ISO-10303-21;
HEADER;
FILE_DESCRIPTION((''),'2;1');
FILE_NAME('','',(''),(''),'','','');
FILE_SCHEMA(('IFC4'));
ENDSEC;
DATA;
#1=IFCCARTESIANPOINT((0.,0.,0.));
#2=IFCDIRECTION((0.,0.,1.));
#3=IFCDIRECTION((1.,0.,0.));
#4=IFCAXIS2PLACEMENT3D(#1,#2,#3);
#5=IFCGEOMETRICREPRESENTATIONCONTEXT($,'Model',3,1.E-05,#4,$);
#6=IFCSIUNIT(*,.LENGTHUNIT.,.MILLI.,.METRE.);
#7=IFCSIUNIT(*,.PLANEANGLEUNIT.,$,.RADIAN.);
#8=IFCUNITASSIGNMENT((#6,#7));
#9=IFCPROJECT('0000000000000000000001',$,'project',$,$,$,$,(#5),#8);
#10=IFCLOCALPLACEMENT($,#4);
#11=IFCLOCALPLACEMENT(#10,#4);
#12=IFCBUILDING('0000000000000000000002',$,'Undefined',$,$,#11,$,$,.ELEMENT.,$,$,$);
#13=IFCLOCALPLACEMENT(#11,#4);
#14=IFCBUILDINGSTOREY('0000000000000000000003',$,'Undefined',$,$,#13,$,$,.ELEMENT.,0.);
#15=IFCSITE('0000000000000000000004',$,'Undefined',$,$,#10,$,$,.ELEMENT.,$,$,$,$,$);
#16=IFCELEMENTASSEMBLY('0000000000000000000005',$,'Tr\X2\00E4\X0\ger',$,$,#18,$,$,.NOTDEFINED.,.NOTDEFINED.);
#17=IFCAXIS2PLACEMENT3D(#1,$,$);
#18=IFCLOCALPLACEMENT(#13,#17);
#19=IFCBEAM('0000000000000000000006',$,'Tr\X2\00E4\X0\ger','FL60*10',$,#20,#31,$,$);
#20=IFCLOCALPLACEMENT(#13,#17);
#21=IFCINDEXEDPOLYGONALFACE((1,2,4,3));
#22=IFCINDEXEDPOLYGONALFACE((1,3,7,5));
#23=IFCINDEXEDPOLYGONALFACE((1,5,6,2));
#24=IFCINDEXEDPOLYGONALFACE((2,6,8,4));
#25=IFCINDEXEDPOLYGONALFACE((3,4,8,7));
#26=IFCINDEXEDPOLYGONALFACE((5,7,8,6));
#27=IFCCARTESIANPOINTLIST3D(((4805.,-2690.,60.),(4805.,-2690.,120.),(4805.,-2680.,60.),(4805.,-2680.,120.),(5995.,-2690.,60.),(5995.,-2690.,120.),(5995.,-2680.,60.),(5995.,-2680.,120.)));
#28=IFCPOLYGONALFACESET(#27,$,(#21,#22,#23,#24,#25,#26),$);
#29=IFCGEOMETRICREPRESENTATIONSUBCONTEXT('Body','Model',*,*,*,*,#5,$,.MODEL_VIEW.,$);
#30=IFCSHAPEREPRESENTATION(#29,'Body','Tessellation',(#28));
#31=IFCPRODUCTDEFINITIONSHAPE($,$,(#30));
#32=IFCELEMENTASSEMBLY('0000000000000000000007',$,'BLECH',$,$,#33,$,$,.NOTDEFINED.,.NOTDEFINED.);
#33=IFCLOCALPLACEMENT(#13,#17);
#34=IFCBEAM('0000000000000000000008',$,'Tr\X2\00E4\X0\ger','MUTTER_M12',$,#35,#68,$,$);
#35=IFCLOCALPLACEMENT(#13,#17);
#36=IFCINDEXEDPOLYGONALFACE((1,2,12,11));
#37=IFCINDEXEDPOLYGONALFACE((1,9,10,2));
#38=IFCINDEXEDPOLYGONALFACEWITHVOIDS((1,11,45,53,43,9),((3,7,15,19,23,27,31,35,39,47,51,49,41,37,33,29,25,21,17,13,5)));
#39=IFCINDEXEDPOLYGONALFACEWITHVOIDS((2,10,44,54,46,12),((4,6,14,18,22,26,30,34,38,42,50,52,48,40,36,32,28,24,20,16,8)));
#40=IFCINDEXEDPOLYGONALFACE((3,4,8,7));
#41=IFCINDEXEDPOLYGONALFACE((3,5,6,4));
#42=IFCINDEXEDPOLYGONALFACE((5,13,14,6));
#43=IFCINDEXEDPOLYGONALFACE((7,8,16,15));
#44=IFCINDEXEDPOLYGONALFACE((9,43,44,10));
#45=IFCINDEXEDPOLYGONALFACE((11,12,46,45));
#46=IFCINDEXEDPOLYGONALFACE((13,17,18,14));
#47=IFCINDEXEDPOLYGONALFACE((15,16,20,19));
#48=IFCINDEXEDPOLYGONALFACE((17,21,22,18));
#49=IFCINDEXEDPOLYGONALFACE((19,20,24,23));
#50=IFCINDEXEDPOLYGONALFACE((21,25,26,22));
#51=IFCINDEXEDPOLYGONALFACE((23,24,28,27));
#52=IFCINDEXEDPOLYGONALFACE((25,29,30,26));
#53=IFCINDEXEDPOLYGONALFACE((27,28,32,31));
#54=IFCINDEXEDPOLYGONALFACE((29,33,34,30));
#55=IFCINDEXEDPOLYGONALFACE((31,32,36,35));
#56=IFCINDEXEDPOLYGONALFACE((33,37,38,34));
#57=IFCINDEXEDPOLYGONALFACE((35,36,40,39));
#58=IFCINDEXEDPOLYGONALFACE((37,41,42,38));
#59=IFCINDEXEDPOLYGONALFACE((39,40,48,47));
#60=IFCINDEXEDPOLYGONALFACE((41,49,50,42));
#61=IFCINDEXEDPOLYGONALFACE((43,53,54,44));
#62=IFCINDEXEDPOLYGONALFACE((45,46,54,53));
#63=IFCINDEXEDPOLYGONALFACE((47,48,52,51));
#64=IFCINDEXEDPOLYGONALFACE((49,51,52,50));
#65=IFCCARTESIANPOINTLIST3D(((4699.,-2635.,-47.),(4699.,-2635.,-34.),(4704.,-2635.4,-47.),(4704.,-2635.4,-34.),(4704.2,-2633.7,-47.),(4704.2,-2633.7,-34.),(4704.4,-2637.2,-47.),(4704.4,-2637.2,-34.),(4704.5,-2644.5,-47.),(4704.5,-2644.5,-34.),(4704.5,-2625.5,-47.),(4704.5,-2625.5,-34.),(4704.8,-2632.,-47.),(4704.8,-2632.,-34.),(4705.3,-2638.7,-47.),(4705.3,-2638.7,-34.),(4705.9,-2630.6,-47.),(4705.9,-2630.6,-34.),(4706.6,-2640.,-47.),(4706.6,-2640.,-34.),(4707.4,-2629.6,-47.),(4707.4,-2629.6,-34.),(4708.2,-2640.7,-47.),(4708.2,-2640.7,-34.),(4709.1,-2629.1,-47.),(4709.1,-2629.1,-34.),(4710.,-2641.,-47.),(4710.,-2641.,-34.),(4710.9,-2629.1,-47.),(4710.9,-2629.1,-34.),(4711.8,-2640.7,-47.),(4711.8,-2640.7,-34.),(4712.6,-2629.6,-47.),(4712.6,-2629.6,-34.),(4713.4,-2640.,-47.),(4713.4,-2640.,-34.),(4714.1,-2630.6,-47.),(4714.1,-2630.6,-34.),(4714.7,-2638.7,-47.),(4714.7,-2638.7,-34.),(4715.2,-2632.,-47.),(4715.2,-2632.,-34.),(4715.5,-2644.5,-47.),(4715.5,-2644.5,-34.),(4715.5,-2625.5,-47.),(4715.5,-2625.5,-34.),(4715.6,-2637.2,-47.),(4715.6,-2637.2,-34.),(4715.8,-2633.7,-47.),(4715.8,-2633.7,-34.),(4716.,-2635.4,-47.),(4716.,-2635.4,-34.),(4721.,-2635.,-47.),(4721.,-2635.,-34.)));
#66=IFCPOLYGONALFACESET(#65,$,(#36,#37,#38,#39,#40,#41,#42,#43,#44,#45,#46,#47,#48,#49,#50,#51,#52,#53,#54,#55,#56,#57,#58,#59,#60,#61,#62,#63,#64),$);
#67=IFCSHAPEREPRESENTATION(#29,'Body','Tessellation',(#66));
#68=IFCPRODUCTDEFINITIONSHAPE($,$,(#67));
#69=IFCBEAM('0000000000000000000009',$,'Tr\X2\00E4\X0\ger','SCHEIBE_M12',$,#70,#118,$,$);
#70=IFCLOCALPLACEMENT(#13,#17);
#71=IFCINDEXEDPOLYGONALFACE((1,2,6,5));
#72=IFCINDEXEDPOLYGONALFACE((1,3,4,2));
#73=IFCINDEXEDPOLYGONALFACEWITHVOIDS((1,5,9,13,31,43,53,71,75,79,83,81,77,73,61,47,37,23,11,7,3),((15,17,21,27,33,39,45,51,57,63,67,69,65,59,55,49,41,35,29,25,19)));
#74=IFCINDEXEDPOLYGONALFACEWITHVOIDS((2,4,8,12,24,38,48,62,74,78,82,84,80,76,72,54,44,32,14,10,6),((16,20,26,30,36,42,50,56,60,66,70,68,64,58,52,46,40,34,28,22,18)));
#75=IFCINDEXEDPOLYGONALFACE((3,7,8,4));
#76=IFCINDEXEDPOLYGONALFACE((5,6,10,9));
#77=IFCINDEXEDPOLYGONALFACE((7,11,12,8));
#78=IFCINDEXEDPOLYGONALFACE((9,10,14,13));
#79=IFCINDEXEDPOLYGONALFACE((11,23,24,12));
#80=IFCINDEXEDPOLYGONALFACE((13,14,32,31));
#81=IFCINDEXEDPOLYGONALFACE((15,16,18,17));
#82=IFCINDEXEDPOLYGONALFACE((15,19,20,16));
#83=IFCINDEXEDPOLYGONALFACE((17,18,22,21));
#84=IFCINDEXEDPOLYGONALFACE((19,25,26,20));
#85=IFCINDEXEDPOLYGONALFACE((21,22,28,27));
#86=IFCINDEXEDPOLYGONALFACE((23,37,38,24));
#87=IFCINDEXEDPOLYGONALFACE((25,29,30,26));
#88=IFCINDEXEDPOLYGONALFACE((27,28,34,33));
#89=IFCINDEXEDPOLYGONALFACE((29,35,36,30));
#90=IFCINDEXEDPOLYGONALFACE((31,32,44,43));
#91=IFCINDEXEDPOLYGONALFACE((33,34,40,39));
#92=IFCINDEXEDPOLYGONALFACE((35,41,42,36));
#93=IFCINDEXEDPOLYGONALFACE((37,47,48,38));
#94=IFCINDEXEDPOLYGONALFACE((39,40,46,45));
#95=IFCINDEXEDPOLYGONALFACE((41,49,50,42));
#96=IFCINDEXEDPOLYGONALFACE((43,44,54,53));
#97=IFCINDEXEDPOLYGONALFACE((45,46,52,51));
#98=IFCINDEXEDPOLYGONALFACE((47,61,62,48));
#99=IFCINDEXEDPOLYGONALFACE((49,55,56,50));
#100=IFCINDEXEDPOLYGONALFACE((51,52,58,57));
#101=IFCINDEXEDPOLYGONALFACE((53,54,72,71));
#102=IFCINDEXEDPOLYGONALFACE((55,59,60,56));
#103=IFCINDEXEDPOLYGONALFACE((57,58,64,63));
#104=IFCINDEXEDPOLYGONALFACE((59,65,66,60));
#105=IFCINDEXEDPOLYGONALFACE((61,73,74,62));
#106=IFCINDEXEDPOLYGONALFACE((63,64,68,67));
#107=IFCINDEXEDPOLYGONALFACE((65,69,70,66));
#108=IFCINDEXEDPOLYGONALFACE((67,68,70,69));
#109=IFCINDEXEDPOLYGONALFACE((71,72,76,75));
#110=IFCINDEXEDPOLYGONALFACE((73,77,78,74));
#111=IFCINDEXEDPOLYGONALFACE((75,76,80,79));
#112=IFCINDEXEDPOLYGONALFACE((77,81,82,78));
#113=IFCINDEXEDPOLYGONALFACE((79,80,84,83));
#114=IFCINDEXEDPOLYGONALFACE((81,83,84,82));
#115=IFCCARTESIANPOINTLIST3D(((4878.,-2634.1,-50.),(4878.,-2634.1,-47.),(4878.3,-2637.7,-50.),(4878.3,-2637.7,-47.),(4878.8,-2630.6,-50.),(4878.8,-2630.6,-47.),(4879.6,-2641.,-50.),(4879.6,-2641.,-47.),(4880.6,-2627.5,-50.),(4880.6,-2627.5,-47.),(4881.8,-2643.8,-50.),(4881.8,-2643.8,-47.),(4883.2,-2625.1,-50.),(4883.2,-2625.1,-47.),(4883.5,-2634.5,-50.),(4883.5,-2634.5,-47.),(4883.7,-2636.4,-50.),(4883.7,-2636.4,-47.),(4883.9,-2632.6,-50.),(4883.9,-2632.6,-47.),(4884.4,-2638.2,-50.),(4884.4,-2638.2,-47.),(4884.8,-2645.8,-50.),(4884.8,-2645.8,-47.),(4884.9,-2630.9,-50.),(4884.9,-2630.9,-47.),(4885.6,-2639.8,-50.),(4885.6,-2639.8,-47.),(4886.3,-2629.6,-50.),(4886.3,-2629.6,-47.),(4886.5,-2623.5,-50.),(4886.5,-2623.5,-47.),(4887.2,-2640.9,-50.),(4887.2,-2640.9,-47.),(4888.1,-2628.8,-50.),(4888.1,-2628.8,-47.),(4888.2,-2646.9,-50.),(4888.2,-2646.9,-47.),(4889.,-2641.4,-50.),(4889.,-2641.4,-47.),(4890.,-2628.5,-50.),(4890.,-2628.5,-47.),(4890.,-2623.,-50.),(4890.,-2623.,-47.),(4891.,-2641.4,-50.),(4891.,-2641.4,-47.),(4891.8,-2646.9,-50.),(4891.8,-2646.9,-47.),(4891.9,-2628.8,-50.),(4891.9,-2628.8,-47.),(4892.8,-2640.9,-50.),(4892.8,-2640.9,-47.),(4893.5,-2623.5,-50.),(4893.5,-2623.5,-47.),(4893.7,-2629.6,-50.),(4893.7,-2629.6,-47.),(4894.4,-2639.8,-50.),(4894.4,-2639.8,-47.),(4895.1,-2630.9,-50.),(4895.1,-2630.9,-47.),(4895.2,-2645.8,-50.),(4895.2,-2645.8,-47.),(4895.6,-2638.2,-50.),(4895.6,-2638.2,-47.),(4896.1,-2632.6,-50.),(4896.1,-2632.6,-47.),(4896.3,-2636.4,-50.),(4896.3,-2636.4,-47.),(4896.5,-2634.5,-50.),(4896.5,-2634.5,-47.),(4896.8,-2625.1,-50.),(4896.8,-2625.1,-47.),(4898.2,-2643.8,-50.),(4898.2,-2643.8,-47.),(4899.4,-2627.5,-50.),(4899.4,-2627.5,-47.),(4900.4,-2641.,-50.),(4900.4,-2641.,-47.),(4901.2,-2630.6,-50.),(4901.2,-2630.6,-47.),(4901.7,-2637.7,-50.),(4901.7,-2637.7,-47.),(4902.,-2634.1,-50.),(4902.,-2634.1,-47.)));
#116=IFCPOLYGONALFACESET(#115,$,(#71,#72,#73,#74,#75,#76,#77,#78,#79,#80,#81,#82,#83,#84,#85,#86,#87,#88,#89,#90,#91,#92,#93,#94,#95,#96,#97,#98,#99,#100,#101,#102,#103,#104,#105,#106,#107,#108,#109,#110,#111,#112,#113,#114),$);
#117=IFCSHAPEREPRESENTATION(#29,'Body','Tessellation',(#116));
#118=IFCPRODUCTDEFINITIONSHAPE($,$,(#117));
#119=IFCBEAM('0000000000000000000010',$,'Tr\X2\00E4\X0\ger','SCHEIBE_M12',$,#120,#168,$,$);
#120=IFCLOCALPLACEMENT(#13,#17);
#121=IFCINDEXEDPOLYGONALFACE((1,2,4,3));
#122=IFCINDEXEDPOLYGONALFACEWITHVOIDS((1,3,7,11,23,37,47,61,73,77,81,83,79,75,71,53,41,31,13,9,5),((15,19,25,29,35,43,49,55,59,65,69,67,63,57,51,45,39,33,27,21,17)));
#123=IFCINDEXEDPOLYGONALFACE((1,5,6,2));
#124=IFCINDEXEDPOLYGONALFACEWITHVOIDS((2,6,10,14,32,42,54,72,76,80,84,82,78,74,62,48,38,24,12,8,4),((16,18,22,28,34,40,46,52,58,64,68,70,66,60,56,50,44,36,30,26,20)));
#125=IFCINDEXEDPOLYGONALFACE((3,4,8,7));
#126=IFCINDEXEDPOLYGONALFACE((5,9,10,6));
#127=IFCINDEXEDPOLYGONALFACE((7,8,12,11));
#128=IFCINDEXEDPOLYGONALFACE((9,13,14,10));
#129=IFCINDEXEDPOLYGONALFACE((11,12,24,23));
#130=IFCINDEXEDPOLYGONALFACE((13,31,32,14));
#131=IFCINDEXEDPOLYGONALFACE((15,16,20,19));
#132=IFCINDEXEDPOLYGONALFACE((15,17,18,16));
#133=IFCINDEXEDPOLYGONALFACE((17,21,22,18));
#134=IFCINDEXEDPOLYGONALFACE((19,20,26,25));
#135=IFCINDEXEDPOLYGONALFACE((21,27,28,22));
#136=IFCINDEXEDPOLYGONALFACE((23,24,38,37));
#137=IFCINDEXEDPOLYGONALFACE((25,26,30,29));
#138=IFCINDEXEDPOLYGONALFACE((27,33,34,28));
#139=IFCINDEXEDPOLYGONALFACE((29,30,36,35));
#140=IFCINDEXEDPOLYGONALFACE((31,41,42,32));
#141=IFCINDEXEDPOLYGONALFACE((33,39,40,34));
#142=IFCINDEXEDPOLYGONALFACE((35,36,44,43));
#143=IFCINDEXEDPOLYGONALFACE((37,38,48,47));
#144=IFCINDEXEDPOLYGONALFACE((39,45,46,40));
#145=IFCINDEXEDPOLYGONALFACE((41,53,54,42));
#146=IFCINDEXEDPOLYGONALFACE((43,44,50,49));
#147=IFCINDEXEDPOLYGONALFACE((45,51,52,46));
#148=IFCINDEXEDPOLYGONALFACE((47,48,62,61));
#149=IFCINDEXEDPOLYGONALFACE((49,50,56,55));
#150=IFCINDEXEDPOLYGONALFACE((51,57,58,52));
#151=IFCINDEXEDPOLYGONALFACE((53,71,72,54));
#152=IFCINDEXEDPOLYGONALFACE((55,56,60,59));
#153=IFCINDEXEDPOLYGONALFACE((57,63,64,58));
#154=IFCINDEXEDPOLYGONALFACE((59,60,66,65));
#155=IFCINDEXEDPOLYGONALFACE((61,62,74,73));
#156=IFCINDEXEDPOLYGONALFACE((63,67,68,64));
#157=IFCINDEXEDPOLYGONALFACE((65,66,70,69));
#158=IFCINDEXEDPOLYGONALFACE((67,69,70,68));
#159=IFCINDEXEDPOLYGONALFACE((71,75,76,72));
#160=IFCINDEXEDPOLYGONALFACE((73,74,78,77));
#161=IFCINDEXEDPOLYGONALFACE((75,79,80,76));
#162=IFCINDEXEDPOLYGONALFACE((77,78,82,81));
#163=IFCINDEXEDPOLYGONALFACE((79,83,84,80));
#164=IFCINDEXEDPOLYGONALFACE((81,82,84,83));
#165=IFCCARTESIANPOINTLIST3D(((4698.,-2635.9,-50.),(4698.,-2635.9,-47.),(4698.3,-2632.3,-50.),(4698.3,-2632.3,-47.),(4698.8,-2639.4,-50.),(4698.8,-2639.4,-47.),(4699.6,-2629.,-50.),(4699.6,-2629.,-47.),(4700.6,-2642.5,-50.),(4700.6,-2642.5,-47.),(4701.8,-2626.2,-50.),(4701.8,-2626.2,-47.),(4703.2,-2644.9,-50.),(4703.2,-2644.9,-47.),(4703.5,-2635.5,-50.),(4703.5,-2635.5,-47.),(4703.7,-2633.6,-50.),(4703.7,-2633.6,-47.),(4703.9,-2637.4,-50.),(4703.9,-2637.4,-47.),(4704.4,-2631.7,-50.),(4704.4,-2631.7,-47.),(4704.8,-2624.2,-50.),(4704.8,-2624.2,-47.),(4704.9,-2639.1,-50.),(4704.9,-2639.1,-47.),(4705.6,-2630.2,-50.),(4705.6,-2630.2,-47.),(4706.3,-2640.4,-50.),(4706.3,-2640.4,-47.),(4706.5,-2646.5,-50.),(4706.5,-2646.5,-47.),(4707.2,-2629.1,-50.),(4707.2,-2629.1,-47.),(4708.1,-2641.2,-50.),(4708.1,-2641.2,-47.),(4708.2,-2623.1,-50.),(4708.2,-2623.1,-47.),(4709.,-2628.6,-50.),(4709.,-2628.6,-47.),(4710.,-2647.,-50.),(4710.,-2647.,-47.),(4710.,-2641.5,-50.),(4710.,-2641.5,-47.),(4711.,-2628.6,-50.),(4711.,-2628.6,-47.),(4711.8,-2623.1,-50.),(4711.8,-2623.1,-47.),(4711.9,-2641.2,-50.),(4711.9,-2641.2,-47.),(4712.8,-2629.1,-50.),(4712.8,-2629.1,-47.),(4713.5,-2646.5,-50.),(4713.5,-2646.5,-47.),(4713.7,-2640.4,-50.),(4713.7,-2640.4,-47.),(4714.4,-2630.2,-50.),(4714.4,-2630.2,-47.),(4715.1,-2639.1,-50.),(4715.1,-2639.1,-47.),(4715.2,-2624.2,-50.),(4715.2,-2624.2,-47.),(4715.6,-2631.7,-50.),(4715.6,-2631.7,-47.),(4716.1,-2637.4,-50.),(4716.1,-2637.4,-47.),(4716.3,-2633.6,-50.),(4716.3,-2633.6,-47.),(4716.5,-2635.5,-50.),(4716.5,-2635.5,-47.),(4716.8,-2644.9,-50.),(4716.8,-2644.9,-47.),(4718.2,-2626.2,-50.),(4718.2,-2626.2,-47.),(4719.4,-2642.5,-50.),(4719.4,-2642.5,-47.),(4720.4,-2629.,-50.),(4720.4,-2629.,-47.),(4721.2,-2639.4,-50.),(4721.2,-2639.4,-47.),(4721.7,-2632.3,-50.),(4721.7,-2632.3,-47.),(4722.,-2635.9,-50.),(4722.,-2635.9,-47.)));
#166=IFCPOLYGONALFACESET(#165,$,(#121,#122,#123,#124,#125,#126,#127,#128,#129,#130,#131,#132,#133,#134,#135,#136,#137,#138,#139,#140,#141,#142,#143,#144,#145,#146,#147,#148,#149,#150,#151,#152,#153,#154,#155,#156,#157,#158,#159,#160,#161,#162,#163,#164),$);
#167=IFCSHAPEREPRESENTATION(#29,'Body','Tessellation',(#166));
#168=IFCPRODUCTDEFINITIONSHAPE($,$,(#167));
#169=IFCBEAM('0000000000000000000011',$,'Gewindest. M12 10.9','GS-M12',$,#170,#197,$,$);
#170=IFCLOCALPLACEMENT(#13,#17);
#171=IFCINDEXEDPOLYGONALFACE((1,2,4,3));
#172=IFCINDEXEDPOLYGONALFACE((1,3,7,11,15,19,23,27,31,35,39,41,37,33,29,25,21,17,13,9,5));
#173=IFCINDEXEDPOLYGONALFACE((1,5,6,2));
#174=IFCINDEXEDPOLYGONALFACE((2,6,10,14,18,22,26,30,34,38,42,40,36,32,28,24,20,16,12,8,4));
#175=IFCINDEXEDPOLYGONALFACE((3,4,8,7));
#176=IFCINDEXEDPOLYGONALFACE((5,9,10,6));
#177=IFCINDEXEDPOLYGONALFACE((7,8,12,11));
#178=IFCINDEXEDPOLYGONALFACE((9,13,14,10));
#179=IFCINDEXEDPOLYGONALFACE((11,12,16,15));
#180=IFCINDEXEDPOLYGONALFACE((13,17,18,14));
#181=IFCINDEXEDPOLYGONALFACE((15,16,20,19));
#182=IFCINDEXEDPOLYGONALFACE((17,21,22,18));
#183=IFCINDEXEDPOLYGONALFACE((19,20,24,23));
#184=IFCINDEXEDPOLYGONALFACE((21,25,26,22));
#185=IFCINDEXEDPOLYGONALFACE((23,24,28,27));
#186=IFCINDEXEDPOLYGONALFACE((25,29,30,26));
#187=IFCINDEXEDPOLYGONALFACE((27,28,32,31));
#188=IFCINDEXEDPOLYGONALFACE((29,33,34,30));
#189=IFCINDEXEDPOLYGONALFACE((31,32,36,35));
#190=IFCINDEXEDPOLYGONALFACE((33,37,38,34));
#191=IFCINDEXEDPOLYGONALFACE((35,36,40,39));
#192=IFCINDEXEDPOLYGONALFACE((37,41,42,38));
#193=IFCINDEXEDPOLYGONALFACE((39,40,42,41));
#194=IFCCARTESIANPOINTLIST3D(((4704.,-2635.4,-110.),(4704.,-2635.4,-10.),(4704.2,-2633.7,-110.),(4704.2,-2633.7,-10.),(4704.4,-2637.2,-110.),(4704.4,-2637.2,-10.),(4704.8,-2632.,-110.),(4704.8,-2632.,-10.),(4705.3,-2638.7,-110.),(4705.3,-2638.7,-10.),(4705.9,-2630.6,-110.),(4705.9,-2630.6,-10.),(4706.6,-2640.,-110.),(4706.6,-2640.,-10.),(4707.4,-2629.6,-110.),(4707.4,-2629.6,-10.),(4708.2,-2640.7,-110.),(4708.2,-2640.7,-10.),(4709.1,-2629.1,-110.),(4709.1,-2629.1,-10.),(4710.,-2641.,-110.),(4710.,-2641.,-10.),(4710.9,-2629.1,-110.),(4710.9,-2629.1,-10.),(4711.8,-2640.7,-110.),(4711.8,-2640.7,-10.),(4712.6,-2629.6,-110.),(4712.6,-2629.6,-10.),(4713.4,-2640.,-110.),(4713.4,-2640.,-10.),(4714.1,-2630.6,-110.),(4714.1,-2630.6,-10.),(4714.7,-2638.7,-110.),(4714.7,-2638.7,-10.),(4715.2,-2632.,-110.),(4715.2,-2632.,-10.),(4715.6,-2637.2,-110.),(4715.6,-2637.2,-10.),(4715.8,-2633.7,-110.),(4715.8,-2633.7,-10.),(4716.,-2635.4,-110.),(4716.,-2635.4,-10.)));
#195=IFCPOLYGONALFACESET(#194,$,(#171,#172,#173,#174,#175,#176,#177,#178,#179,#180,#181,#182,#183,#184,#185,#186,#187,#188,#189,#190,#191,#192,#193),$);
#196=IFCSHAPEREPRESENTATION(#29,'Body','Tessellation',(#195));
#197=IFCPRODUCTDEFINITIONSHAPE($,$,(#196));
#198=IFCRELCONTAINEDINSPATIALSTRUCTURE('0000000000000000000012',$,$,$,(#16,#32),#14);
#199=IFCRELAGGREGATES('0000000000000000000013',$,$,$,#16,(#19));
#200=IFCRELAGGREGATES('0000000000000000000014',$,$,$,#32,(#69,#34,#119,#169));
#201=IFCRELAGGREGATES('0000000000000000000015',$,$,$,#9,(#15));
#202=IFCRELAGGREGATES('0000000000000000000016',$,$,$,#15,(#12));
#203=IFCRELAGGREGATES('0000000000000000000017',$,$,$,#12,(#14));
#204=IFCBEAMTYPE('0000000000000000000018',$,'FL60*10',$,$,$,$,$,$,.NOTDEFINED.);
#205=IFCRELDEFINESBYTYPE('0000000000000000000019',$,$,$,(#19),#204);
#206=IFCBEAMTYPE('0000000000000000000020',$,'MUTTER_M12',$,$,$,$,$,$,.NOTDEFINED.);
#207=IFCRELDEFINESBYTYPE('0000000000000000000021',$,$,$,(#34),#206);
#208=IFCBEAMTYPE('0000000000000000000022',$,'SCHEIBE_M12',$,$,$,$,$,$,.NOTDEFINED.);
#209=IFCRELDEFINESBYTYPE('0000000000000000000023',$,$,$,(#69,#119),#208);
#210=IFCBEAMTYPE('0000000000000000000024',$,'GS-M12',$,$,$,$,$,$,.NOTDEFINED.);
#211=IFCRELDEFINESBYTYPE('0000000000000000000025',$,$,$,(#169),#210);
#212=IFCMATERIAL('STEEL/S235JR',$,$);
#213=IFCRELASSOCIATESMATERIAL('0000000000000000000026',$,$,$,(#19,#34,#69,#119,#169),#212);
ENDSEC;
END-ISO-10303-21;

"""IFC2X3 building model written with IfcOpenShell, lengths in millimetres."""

from ifc_helpers import new_model, si_unit, frame, origin_with_axes, origin_2d_with_axis, place, context, subcontext, project, spatial, polyline, rectangle, circle, hollow_circle, outline, extrude, boolean, material, type_object, element, aggregate, save


model = new_model("IFC2X3")

# Units and contexts
model_context = context("Model", 3, precision=1e-05, world=origin_with_axes())
body_context = subcontext(model_context, "Body", "Model", "MODEL_VIEW")
ifc_project = project(units=[si_unit("LENGTHUNIT", "METRE", prefix="MILLI"), si_unit("PLANEANGLEUNIT", "RADIAN")], contexts=[model_context])

# Site, building, storey
site_placement = place(None, origin_with_axes())
site = spatial("IfcSite", under=ifc_project, at=site_placement, Name="Undefined", CompositionType="ELEMENT")
building_placement = place(site_placement, origin_with_axes())
building = spatial("IfcBuilding", under=site, at=building_placement, Name="Undefined", CompositionType="ELEMENT")
storey_placement = place(building_placement, origin_with_axes())
storey = spatial("IfcBuildingStorey", under=building, at=storey_placement, Name="Undefined", CompositionType="ELEMENT", Elevation=0.0)

# Element assembly, beam
assembly_1_placement = place(storey_placement, origin_with_axes())
assembly_1 = element("IfcElementAssembly", 1, at=assembly_1_placement, inside=storey, Name="Träger", AssemblyPlace="NOTDEFINED", PredefinedType="NOTDEFINED")
ifc_material_1 = material(Name="STEEL/S235JR")
beam_type_1 = type_object("IfcBeamType", Name="FL60*10", PredefinedType="NOTDEFINED")
beam_1_placement = place(assembly_1_placement, frame((4805.0, -2685.0, 90.0), z_axis=(0.0, 0.0, 1.0), x_axis=(1.0, 0.0, 0.0)))
beam_1 = element("IfcBeam", 2, at=beam_1_placement, type_object=beam_type_1, material=ifc_material_1, Name="Träger", Description="FL60*10", context=body_context, shape_type="SweptSolid", body=[
    extrude(rectangle(XDim=10.0, YDim=60.0, at=origin_2d_with_axis()), frame((1190.0, 0.0, 0.0), z_axis=(-1.0, 0.0, 0.0), x_axis=(0.0, -1.0, 0.0)), (0.0, 0.0, 1.0), 1190.0),
])
aggregate(assembly_1, [beam_1])

# Element assembly, beams
assembly_2_placement = place(storey_placement, origin_with_axes())
assembly_2 = element("IfcElementAssembly", 3, at=assembly_2_placement, inside=storey, Name="BLECH", AssemblyPlace="NOTDEFINED", PredefinedType="NOTDEFINED")
beam_type_2 = type_object("IfcBeamType", Name="MUTTER_M12", PredefinedType="NOTDEFINED")
beam_2_placement = place(assembly_2_placement, frame((4710.0, -2635.0, -34.0), z_axis=(1.0, 0.0, 0.0), x_axis=(0.0, 0.0, -1.0)))
beam_2 = element("IfcBeam", 4, at=beam_2_placement, type_object=beam_type_2, material=ifc_material_1, Name="Träger", Description="MUTTER_M12", context=body_context, shape_type="CSG", body=[
    boolean("DIFFERENCE", extrude(outline(polyline([(9.5, 5.5), (9.5, -5.5), (0.0, -11.0), (-9.5, -5.5), (-9.5, 5.5), (0.0, 11.0), (9.5, 5.5)])), frame((13.0, 0.0, 0.0), z_axis=(-1.0, 0.0, 0.0), x_axis=(0.0, -1.0, 0.0)), (0.0, 0.0, 1.0), 13.0), extrude(circle(Radius=6.0, at=origin_2d_with_axis()), frame((36.0, 0.0, 0.0), z_axis=(-1.0, 0.0, 0.0), x_axis=(0.0, -1.0, 0.0)), (0.0, 0.0, 1.0), 60.0)),
])
beam_type_3 = type_object("IfcBeamType", Name="SCHEIBE_M12", PredefinedType="NOTDEFINED")
beam_3_placement = place(assembly_2_placement, frame((4890.0, -2635.0, -47.0), z_axis=(-1.0, 0.0, 0.0), x_axis=(0.0, 0.0, -1.0)))
beam_3 = element("IfcBeam", 5, at=beam_3_placement, type_object=beam_type_3, material=ifc_material_1, Name="Träger", Description="SCHEIBE_M12", context=body_context, shape_type="SweptSolid", body=[
    extrude(hollow_circle(Radius=12.0, WallThickness=5.5, at=origin_2d_with_axis()), frame((3.0, 0.0, 0.0), z_axis=(-1.0, 0.0, 0.0), x_axis=(0.0, -1.0, 0.0)), (0.0, 0.0, 1.0), 3.0),
])
beam_4_placement = place(assembly_2_placement, frame((4710.0, -2635.0, -47.0), z_axis=(1.0, 0.0, 0.0), x_axis=(0.0, 0.0, -1.0)))
beam_4 = element("IfcBeam", 6, at=beam_4_placement, type_object=beam_type_3, material=ifc_material_1, Name="Träger", Description="SCHEIBE_M12", context=body_context, shape_type="SweptSolid", body=[
    extrude(hollow_circle(Radius=12.0, WallThickness=5.5, at=origin_2d_with_axis()), frame((3.0, 0.0, 0.0), z_axis=(-1.0, 0.0, 0.0), x_axis=(0.0, -1.0, 0.0)), (0.0, 0.0, 1.0), 3.0),
])
beam_type_4 = type_object("IfcBeamType", Name="GS-M12", PredefinedType="NOTDEFINED")
beam_5_placement = place(assembly_2_placement, frame((4710.0, -2635.0, -10.0), z_axis=(1.0, 0.0, 0.0), x_axis=(0.0, 0.0, -1.0)))
beam_5 = element("IfcBeam", 7, at=beam_5_placement, type_object=beam_type_4, material=ifc_material_1, Name="Gewindest. M12 10.9", Description="GS-M12", context=body_context, shape_type="SweptSolid", body=[
    extrude(circle(Radius=6.0, at=origin_2d_with_axis()), frame((100.0, 0.0, 0.0), z_axis=(-1.0, 0.0, 0.0), x_axis=(0.0, -1.0, 0.0)), (0.0, 0.0, 1.0), 100.0),
])
aggregate(assembly_2, [beam_3, beam_2, beam_4, beam_5])

save(model, "model.ifc")
